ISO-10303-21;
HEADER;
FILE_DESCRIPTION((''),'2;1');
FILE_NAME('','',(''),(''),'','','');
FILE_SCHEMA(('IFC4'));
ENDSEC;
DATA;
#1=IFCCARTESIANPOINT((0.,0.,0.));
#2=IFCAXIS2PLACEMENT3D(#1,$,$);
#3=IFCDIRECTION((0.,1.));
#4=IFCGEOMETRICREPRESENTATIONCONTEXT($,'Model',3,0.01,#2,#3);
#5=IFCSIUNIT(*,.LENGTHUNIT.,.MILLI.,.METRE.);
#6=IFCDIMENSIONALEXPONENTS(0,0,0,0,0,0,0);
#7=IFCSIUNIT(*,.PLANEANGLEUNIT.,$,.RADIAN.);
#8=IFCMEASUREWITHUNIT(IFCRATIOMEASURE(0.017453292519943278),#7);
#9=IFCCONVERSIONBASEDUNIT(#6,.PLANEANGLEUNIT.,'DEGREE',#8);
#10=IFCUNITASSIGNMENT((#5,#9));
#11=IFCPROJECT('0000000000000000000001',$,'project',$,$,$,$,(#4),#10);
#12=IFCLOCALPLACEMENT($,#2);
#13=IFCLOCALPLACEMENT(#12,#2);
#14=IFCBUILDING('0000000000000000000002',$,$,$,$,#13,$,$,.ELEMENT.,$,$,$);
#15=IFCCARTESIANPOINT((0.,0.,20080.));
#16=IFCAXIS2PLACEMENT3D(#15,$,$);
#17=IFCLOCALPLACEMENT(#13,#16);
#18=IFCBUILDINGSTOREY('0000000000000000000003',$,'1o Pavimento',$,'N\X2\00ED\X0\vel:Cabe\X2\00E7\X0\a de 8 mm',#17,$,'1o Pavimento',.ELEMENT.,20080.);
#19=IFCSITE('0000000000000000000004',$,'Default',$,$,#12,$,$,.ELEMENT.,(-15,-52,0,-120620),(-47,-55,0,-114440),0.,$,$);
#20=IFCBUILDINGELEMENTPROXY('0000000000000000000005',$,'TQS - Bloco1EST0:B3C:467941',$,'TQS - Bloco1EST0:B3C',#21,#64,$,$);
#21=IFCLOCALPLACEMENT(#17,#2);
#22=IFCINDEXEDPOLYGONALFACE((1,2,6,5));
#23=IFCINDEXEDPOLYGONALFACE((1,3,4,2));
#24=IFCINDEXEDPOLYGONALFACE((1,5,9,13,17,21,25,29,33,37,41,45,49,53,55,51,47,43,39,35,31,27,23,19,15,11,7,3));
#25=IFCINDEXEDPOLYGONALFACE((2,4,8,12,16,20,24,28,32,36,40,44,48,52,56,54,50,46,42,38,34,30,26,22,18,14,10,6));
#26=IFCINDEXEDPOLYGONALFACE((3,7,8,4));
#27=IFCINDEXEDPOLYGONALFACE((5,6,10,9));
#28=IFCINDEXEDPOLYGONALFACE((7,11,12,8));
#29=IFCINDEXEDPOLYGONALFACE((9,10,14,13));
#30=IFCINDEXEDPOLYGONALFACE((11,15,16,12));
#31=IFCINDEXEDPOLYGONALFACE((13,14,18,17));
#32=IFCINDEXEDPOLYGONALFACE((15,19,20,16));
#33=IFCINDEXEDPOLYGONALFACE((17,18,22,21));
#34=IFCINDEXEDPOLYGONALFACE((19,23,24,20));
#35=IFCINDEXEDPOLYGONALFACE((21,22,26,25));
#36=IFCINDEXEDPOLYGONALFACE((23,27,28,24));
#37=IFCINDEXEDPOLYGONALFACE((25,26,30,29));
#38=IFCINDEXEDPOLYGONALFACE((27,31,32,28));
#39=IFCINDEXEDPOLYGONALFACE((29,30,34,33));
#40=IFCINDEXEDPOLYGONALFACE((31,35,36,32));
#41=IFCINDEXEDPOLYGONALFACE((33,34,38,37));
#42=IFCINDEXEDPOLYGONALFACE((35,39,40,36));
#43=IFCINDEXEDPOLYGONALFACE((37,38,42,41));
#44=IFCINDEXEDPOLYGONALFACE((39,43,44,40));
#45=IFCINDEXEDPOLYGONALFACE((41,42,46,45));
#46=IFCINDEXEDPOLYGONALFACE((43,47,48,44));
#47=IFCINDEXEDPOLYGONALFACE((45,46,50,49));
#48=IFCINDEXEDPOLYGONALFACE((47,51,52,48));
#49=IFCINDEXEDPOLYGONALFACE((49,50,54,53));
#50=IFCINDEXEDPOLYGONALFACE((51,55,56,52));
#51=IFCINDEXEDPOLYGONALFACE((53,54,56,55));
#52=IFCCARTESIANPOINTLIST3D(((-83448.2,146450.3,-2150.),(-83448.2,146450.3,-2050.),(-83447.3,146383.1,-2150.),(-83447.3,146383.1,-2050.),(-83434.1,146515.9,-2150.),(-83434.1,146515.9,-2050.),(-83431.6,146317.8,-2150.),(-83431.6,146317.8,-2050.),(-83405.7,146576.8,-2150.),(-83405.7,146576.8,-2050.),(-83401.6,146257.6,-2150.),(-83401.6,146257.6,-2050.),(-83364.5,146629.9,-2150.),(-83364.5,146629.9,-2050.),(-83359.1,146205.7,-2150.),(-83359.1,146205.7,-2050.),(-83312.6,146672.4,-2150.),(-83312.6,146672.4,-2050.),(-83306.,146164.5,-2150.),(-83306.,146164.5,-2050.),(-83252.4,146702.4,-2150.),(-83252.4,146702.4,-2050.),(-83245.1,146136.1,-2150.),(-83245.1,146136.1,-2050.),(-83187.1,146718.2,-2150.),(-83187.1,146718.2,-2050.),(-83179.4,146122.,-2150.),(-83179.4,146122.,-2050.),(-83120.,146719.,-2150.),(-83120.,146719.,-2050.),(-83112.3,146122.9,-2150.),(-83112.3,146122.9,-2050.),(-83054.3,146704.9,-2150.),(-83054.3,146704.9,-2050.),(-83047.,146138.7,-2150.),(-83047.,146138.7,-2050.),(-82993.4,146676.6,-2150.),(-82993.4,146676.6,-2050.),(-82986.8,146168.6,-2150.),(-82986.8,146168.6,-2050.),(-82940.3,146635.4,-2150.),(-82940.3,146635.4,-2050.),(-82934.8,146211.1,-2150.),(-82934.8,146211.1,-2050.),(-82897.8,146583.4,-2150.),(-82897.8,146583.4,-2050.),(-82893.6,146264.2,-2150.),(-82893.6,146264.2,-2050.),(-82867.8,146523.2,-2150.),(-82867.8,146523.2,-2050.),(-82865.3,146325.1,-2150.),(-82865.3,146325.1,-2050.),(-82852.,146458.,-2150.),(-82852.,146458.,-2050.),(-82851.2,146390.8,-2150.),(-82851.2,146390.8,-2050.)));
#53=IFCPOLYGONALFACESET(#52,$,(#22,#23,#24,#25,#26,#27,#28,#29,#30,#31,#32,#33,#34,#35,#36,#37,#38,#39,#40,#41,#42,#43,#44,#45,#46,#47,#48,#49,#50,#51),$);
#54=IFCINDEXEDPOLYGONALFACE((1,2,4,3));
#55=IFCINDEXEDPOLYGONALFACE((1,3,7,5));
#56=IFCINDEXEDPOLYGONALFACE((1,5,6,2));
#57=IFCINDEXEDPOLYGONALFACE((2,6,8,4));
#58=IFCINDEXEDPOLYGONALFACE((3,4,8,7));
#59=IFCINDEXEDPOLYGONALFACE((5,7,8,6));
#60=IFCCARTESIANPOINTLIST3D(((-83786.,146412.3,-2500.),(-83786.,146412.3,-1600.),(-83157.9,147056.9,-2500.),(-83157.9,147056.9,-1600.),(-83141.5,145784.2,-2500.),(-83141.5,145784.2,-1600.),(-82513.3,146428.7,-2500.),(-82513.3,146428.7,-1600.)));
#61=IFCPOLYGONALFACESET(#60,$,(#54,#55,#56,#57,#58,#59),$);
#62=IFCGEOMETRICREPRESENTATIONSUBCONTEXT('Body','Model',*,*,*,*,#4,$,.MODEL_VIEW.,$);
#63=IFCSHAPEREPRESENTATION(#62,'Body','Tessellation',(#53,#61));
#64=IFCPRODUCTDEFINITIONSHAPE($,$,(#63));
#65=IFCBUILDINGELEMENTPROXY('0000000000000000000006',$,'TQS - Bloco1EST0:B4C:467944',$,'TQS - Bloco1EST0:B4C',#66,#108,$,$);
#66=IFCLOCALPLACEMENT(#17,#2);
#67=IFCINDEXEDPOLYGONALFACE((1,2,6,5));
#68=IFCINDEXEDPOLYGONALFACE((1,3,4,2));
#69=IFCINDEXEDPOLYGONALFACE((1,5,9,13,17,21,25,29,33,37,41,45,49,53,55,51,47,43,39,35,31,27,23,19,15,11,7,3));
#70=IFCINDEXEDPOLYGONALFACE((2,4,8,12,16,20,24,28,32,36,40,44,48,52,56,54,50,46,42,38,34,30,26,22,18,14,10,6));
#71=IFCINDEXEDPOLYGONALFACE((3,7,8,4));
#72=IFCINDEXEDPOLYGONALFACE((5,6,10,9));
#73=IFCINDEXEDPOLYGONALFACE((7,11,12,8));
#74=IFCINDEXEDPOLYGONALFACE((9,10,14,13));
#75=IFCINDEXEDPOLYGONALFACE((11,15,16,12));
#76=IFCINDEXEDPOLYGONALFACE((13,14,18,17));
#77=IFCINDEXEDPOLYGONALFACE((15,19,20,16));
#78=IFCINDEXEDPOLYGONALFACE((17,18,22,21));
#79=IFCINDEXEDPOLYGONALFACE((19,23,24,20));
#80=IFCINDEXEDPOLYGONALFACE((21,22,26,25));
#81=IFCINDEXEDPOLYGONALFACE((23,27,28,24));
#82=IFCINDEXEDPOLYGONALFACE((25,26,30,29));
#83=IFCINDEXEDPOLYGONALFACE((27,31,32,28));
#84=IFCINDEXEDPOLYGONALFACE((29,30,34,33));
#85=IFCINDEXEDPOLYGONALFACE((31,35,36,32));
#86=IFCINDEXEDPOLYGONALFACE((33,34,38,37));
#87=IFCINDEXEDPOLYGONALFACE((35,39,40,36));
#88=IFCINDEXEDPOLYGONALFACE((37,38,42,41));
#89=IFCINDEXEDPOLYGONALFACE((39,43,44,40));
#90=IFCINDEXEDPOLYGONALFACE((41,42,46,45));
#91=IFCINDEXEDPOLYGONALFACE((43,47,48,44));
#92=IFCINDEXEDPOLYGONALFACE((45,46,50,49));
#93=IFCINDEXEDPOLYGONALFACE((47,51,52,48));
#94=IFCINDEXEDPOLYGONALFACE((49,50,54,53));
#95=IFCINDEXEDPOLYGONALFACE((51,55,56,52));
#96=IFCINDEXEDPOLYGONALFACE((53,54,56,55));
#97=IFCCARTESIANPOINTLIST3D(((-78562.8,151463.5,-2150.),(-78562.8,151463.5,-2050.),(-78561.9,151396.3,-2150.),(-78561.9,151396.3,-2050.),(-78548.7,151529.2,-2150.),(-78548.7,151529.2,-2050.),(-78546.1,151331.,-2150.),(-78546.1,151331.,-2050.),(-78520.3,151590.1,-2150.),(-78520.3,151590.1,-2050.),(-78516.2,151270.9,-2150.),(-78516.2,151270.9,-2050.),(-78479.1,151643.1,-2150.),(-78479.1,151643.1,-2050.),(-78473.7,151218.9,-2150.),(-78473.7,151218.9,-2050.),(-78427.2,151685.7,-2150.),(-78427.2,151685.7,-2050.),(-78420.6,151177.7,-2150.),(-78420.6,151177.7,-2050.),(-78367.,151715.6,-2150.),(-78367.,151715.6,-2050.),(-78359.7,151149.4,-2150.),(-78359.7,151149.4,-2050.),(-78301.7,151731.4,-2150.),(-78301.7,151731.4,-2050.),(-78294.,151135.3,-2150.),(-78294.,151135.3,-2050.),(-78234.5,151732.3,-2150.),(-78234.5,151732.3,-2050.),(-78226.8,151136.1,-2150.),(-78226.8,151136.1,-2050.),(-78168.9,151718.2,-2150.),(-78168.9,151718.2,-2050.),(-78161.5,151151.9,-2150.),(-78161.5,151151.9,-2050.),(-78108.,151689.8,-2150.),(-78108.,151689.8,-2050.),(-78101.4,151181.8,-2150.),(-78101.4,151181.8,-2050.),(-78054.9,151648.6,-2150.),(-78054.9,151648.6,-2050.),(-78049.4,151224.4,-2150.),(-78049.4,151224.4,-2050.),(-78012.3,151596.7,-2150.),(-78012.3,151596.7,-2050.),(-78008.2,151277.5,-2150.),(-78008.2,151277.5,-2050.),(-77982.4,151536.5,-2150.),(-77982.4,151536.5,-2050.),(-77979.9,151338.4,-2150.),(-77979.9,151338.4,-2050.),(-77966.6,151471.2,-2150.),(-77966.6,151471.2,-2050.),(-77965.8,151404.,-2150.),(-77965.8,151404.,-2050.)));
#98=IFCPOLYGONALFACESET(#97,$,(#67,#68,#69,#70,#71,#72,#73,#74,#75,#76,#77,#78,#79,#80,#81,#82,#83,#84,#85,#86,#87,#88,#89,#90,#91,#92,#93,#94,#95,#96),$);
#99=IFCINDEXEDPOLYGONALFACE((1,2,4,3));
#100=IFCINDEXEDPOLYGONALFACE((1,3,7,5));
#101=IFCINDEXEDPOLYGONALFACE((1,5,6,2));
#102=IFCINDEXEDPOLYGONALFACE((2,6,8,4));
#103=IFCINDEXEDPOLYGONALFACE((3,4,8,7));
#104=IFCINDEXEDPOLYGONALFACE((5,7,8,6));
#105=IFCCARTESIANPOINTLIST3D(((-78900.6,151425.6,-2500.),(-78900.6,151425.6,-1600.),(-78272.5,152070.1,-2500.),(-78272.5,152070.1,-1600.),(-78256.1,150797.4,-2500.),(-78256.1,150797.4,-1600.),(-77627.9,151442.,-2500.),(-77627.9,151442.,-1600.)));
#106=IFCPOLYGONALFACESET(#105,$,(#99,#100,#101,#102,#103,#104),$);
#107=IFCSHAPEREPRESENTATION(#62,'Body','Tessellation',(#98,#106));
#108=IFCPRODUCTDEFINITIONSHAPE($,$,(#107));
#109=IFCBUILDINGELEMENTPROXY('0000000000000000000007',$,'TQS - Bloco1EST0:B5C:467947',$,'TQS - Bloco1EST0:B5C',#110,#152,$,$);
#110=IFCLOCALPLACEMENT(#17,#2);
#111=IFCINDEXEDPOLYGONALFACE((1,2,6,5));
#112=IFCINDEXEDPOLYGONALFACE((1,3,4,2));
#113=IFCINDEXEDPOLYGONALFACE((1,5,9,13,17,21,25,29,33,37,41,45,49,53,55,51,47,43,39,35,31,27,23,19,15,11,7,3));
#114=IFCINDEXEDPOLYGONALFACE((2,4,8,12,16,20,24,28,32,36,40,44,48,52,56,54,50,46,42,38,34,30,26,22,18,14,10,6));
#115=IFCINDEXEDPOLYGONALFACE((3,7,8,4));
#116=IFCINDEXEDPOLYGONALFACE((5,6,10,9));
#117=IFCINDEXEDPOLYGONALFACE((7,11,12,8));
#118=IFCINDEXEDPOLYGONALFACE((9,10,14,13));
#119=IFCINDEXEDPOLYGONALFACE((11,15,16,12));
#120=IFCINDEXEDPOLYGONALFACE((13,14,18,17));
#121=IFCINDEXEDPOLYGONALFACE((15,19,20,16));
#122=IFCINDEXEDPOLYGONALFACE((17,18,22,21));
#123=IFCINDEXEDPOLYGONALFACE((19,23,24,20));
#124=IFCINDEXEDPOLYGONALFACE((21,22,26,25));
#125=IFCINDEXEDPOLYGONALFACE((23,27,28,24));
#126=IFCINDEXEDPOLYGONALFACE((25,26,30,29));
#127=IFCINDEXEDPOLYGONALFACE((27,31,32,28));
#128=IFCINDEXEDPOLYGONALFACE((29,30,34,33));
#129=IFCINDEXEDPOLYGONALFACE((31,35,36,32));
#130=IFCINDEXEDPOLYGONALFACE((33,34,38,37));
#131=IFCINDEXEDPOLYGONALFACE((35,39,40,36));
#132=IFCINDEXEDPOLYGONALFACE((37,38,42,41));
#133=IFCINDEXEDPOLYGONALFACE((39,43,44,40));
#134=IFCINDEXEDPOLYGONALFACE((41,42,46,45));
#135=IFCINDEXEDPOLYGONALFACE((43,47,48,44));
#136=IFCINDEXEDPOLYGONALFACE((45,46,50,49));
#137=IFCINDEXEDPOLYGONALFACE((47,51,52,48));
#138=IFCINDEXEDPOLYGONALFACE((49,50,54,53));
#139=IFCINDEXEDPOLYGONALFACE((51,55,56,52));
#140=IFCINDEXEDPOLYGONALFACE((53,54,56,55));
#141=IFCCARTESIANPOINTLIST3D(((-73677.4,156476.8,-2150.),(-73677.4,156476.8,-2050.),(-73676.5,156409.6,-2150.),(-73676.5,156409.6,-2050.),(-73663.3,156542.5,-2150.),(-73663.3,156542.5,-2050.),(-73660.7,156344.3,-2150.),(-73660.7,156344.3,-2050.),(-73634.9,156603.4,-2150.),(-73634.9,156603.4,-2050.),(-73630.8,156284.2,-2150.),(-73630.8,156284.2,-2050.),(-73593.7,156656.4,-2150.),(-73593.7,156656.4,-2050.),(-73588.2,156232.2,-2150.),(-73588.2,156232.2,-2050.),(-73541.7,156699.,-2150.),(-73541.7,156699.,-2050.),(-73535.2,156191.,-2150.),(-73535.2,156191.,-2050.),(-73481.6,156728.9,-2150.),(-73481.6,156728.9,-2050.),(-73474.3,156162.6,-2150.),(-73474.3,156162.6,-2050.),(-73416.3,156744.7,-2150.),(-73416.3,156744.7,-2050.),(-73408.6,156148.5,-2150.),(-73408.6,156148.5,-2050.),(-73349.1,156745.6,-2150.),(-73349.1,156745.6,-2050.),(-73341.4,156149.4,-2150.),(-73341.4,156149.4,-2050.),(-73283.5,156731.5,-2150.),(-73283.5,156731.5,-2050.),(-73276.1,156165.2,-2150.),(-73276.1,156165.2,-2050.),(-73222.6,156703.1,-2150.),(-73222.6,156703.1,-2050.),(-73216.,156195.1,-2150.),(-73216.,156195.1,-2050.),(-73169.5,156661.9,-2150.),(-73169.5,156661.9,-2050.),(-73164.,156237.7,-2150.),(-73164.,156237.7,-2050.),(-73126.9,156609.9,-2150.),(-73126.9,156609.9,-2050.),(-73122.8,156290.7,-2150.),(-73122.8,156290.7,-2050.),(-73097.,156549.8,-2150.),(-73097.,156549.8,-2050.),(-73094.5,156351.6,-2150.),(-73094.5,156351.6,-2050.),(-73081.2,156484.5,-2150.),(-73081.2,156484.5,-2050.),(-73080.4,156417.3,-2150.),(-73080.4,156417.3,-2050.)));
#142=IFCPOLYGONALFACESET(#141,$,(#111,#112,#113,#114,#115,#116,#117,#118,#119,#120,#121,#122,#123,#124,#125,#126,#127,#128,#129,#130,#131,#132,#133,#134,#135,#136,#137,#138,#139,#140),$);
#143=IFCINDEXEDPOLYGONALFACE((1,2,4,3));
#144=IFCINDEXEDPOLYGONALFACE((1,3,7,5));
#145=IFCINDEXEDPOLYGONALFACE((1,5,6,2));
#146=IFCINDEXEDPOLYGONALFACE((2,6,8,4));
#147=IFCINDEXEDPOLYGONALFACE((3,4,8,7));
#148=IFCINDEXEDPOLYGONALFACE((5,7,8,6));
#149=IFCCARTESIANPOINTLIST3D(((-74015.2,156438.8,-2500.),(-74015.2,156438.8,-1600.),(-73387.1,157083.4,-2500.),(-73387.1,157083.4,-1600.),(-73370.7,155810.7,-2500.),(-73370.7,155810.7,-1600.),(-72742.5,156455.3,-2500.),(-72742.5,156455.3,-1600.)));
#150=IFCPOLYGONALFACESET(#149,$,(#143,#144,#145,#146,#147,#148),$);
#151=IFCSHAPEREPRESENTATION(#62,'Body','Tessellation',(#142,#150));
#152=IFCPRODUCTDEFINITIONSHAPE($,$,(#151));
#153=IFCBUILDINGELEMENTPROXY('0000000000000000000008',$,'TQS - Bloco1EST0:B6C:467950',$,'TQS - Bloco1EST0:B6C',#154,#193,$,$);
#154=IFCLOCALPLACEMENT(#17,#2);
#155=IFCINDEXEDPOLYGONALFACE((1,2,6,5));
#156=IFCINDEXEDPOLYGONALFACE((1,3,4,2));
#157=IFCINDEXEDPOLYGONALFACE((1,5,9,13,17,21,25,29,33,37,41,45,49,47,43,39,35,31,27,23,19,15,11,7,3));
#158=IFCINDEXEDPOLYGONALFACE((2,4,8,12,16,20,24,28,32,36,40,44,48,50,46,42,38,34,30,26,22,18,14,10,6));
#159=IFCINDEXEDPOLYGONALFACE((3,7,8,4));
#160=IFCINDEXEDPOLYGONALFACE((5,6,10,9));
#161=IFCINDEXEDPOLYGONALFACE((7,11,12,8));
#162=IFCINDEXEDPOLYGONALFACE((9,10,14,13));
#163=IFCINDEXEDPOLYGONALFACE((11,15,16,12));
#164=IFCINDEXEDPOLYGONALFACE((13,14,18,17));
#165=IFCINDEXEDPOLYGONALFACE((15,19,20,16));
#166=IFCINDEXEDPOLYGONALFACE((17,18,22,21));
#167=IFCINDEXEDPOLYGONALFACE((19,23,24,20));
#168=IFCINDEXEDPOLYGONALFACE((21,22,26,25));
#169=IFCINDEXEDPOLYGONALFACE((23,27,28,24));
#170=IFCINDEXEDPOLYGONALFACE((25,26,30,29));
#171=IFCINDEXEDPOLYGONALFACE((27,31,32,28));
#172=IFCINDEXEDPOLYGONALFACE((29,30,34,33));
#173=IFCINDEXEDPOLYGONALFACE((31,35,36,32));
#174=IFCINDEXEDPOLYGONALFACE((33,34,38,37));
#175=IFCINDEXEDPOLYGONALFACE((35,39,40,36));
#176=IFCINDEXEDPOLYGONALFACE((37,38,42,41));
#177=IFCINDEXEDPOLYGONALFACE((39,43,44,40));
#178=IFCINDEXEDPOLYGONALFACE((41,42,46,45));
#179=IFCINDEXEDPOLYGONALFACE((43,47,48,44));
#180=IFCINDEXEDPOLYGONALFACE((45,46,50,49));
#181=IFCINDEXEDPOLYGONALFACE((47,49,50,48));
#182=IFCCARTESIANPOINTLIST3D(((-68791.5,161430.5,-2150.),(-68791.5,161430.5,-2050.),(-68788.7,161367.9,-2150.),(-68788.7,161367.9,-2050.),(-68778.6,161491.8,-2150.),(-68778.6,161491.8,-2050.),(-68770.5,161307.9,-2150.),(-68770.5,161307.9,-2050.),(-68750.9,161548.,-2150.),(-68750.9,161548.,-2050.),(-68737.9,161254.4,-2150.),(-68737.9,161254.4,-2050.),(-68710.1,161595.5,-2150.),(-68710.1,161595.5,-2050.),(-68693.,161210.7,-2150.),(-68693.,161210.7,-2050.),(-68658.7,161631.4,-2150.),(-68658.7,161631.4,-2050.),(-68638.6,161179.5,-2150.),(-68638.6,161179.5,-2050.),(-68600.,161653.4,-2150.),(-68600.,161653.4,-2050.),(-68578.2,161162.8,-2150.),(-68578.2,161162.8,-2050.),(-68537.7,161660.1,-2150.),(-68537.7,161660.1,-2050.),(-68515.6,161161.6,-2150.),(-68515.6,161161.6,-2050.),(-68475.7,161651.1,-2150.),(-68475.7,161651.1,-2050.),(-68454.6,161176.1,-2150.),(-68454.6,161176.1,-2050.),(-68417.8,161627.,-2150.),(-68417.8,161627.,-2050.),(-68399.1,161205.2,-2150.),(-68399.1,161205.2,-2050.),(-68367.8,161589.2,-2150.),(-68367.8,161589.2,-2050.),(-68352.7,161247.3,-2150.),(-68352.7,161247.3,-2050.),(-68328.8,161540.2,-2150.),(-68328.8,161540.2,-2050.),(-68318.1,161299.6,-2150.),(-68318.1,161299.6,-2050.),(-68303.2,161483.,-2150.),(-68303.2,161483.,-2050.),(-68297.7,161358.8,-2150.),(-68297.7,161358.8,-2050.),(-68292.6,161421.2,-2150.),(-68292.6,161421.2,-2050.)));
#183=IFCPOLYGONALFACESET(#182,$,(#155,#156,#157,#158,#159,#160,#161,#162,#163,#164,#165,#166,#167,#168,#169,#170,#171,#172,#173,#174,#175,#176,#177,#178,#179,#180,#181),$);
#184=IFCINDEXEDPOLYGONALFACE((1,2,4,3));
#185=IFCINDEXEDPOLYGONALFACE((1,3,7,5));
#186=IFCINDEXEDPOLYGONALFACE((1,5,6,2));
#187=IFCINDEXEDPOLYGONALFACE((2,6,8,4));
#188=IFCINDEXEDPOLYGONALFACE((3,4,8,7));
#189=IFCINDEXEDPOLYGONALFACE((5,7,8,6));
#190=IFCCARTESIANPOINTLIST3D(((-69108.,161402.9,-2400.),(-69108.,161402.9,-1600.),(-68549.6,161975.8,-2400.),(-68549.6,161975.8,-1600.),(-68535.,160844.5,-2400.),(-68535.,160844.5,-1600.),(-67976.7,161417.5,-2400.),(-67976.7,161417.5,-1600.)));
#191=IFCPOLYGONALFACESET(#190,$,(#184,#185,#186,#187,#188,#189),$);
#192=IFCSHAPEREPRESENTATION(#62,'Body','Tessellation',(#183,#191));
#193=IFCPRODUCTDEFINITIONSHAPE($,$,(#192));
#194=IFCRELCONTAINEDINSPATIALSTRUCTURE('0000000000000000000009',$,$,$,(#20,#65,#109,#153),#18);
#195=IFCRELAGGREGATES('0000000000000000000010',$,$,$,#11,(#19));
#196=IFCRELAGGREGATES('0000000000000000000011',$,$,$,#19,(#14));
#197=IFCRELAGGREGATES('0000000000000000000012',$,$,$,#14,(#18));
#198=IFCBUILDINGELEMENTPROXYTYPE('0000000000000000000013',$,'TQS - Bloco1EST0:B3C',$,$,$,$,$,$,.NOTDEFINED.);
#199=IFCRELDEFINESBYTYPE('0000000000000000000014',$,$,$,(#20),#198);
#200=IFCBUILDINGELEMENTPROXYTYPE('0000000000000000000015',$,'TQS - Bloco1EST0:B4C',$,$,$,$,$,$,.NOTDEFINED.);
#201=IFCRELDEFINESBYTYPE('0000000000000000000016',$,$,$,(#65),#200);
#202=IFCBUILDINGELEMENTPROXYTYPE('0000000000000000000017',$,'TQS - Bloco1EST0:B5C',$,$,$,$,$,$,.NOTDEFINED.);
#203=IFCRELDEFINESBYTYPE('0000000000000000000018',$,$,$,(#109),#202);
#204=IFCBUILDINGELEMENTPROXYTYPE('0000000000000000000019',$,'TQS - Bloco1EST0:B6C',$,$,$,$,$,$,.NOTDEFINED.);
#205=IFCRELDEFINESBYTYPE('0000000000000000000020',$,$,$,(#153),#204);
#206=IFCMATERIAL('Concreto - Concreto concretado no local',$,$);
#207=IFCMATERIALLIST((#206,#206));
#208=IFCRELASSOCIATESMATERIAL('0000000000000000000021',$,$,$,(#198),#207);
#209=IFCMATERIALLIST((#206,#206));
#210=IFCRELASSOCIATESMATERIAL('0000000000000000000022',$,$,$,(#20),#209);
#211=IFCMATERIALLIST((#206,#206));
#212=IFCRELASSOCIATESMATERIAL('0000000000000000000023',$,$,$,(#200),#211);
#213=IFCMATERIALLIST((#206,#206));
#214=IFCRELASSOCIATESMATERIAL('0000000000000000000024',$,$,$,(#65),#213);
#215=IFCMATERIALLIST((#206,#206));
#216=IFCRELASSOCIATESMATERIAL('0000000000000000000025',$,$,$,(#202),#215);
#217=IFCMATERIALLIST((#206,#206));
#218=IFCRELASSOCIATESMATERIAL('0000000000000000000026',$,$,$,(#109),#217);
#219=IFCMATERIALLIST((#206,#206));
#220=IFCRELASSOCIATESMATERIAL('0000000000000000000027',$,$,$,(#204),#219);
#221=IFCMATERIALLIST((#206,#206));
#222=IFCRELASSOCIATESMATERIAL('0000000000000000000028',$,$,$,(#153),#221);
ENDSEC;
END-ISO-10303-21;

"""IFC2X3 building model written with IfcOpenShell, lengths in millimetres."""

from ifc_helpers import new_model, entity, si_unit, converted_unit, direction, frame, frame_2d, origin, origin_2d_with_axis, place, context, subcontext, project, spatial, rectangle, circle, extrude, source, transform, mapped, material, material_list, type_object, type_shapes, element, save


model = new_model("IFC2X3")

# Units and contexts
model_context = context("Model", 3, precision=0.01, world=origin(), true_north=direction((0.0, 1.0)))
body_context = subcontext(model_context, "Body", "Model", "MODEL_VIEW")
ifc_project = project(units=[si_unit("LENGTHUNIT", "METRE", prefix="MILLI"), converted_unit("PLANEANGLEUNIT", "DEGREE", entity("IfcRatioMeasure", 0.017453292519943278), si_unit("PLANEANGLEUNIT", "RADIAN"), dimensions=[0, 0, 0, 0, 0, 0, 0])], contexts=[model_context])

# Site, building, storey
site_placement = place(None, origin())
site = spatial("IfcSite", under=ifc_project, at=site_placement, Name="Default", CompositionType="ELEMENT", RefLatitude=(-15, -52, 0, -120620), RefLongitude=(-47, -55, 0, -114440), RefElevation=0.0)
building_placement = place(site_placement, origin())
building = spatial("IfcBuilding", under=site, at=building_placement, CompositionType="ELEMENT")
storey_placement = place(building_placement, frame((0.0, 0.0, 20080.0)))
storey = spatial("IfcBuildingStorey", under=building, at=storey_placement, Name="1o Pavimento", ObjectType="Nível:Cabeça de 8 mm", LongName="1o Pavimento", CompositionType="ELEMENT", Elevation=20080.0)

# Building element proxies
ifc_material_1 = material(Name="Concreto - Concreto concretado no local")
ifc_material_list_1 = material_list([ifc_material_1, ifc_material_1])
ifc_material_list_2 = material_list([ifc_material_1, ifc_material_1])
building_element_proxy_type_1 = type_object("IfcBuildingElementProxyType", Name="TQS - Bloco1EST0:B3C", PredefinedType="NOTDEFINED", material=ifc_material_list_2)
shared_shape_1 = source(origin(), body_context, "Body", "SweptSolid", [
    extrude(circle(Radius=300.0, at=frame_2d((0.0, 0.0), x_axis=(1.0, 0.0))), frame((0.0, 0.0, -550.0)), (0.0, 0.0, 1.0), 100.0),
    extrude(rectangle(XDim=900.0, YDim=900.0, at=origin_2d_with_axis()), frame((0.0, 0.0, -900.0), z_axis=(0.0, 0.0, 1.0), x_axis=(-1.0, 0.0, 0.0)), (0.0, 0.0, 1.0), 900.0),
])
type_shapes(building_element_proxy_type_1, [shared_shape_1])
proxy_1_placement = place(storey_placement, frame((-83149.7, 146420.5, -1600.0), z_axis=(0.0, 0.0, 1.0), x_axis=(0.697915, 0.71618, 0.0)))
element("IfcBuildingElementProxy", 1, at=proxy_1_placement, inside=storey, type_object=building_element_proxy_type_1, material=ifc_material_list_1, Name="TQS - Bloco1EST0:B3C:467941", ObjectType="TQS - Bloco1EST0:B3C", context=body_context, shape_type="MappedRepresentation", body=[
    mapped(shared_shape_1, transform((0.0, 0.0, 0.0), scale=1.0)),
])
ifc_material_list_3 = material_list([ifc_material_1, ifc_material_1])
ifc_material_list_4 = material_list([ifc_material_1, ifc_material_1])
building_element_proxy_type_2 = type_object("IfcBuildingElementProxyType", Name="TQS - Bloco1EST0:B4C", PredefinedType="NOTDEFINED", material=ifc_material_list_4)
shared_shape_2 = source(origin(), body_context, "Body", "SweptSolid", [
    extrude(circle(Radius=300.0, at=frame_2d((0.0, 0.0), x_axis=(1.0, 0.0))), frame((0.0, 0.0, -550.0)), (0.0, 0.0, 1.0), 100.0),
    extrude(rectangle(XDim=900.0, YDim=900.0, at=origin_2d_with_axis()), frame((0.0, 0.0, -900.0), z_axis=(0.0, 0.0, 1.0), x_axis=(-1.0, 0.0, 0.0)), (0.0, 0.0, 1.0), 900.0),
])
type_shapes(building_element_proxy_type_2, [shared_shape_2])
proxy_2_placement = place(storey_placement, frame((-78264.3, 151433.8, -1600.0), z_axis=(0.0, 0.0, 1.0), x_axis=(0.697915, 0.71618, 0.0)))
element("IfcBuildingElementProxy", 2, at=proxy_2_placement, inside=storey, type_object=building_element_proxy_type_2, material=ifc_material_list_3, Name="TQS - Bloco1EST0:B4C:467944", ObjectType="TQS - Bloco1EST0:B4C", context=body_context, shape_type="MappedRepresentation", body=[
    mapped(shared_shape_2, transform((0.0, 0.0, 0.0), scale=1.0)),
])
ifc_material_list_5 = material_list([ifc_material_1, ifc_material_1])
ifc_material_list_6 = material_list([ifc_material_1, ifc_material_1])
building_element_proxy_type_3 = type_object("IfcBuildingElementProxyType", Name="TQS - Bloco1EST0:B5C", PredefinedType="NOTDEFINED", material=ifc_material_list_6)
shared_shape_3 = source(origin(), body_context, "Body", "SweptSolid", [
    extrude(circle(Radius=300.0, at=frame_2d((0.0, 0.0), x_axis=(1.0, 0.0))), frame((0.0, 0.0, -550.0)), (0.0, 0.0, 1.0), 100.0),
    extrude(rectangle(XDim=900.0, YDim=900.0, at=origin_2d_with_axis()), frame((0.0, 0.0, -900.0), z_axis=(0.0, 0.0, 1.0), x_axis=(-1.0, 0.0, 0.0)), (0.0, 0.0, 1.0), 900.0),
])
type_shapes(building_element_proxy_type_3, [shared_shape_3])
proxy_3_placement = place(storey_placement, frame((-73378.9, 156447.0, -1600.0), z_axis=(0.0, 0.0, 1.0), x_axis=(0.697915, 0.71618, 0.0)))
element("IfcBuildingElementProxy", 3, at=proxy_3_placement, inside=storey, type_object=building_element_proxy_type_3, material=ifc_material_list_5, Name="TQS - Bloco1EST0:B5C:467947", ObjectType="TQS - Bloco1EST0:B5C", context=body_context, shape_type="MappedRepresentation", body=[
    mapped(shared_shape_3, transform((0.0, 0.0, 0.0), scale=1.0)),
])
ifc_material_list_7 = material_list([ifc_material_1, ifc_material_1])
ifc_material_list_8 = material_list([ifc_material_1, ifc_material_1])
building_element_proxy_type_4 = type_object("IfcBuildingElementProxyType", Name="TQS - Bloco1EST0:B6C", PredefinedType="NOTDEFINED", material=ifc_material_list_8)
shared_shape_4 = source(origin(), body_context, "Body", "SweptSolid", [
    extrude(circle(Radius=250.0, at=frame_2d((0.0, 0.0), x_axis=(1.0, 0.0))), frame((0.0, 0.0, -550.0)), (0.0, 0.0, 1.0), 100.0),
    extrude(rectangle(XDim=800.0, YDim=800.0, at=origin_2d_with_axis()), frame((0.0, 0.0, -800.0), z_axis=(0.0, 0.0, 1.0), x_axis=(-1.0, 0.0, 0.0)), (0.0, 0.0, 1.0), 800.0),
])
type_shapes(building_element_proxy_type_4, [shared_shape_4])
proxy_4_placement = place(storey_placement, frame((-68542.3, 161410.2, -1600.0), z_axis=(0.0, 0.0, 1.0), x_axis=(0.697915, 0.71618, 0.0)))
element("IfcBuildingElementProxy", 4, at=proxy_4_placement, inside=storey, type_object=building_element_proxy_type_4, material=ifc_material_list_7, Name="TQS - Bloco1EST0:B6C:467950", ObjectType="TQS - Bloco1EST0:B6C", context=body_context, shape_type="MappedRepresentation", body=[
    mapped(shared_shape_4, transform((0.0, 0.0, 0.0), scale=1.0)),
])

save(model, "model.ifc")
